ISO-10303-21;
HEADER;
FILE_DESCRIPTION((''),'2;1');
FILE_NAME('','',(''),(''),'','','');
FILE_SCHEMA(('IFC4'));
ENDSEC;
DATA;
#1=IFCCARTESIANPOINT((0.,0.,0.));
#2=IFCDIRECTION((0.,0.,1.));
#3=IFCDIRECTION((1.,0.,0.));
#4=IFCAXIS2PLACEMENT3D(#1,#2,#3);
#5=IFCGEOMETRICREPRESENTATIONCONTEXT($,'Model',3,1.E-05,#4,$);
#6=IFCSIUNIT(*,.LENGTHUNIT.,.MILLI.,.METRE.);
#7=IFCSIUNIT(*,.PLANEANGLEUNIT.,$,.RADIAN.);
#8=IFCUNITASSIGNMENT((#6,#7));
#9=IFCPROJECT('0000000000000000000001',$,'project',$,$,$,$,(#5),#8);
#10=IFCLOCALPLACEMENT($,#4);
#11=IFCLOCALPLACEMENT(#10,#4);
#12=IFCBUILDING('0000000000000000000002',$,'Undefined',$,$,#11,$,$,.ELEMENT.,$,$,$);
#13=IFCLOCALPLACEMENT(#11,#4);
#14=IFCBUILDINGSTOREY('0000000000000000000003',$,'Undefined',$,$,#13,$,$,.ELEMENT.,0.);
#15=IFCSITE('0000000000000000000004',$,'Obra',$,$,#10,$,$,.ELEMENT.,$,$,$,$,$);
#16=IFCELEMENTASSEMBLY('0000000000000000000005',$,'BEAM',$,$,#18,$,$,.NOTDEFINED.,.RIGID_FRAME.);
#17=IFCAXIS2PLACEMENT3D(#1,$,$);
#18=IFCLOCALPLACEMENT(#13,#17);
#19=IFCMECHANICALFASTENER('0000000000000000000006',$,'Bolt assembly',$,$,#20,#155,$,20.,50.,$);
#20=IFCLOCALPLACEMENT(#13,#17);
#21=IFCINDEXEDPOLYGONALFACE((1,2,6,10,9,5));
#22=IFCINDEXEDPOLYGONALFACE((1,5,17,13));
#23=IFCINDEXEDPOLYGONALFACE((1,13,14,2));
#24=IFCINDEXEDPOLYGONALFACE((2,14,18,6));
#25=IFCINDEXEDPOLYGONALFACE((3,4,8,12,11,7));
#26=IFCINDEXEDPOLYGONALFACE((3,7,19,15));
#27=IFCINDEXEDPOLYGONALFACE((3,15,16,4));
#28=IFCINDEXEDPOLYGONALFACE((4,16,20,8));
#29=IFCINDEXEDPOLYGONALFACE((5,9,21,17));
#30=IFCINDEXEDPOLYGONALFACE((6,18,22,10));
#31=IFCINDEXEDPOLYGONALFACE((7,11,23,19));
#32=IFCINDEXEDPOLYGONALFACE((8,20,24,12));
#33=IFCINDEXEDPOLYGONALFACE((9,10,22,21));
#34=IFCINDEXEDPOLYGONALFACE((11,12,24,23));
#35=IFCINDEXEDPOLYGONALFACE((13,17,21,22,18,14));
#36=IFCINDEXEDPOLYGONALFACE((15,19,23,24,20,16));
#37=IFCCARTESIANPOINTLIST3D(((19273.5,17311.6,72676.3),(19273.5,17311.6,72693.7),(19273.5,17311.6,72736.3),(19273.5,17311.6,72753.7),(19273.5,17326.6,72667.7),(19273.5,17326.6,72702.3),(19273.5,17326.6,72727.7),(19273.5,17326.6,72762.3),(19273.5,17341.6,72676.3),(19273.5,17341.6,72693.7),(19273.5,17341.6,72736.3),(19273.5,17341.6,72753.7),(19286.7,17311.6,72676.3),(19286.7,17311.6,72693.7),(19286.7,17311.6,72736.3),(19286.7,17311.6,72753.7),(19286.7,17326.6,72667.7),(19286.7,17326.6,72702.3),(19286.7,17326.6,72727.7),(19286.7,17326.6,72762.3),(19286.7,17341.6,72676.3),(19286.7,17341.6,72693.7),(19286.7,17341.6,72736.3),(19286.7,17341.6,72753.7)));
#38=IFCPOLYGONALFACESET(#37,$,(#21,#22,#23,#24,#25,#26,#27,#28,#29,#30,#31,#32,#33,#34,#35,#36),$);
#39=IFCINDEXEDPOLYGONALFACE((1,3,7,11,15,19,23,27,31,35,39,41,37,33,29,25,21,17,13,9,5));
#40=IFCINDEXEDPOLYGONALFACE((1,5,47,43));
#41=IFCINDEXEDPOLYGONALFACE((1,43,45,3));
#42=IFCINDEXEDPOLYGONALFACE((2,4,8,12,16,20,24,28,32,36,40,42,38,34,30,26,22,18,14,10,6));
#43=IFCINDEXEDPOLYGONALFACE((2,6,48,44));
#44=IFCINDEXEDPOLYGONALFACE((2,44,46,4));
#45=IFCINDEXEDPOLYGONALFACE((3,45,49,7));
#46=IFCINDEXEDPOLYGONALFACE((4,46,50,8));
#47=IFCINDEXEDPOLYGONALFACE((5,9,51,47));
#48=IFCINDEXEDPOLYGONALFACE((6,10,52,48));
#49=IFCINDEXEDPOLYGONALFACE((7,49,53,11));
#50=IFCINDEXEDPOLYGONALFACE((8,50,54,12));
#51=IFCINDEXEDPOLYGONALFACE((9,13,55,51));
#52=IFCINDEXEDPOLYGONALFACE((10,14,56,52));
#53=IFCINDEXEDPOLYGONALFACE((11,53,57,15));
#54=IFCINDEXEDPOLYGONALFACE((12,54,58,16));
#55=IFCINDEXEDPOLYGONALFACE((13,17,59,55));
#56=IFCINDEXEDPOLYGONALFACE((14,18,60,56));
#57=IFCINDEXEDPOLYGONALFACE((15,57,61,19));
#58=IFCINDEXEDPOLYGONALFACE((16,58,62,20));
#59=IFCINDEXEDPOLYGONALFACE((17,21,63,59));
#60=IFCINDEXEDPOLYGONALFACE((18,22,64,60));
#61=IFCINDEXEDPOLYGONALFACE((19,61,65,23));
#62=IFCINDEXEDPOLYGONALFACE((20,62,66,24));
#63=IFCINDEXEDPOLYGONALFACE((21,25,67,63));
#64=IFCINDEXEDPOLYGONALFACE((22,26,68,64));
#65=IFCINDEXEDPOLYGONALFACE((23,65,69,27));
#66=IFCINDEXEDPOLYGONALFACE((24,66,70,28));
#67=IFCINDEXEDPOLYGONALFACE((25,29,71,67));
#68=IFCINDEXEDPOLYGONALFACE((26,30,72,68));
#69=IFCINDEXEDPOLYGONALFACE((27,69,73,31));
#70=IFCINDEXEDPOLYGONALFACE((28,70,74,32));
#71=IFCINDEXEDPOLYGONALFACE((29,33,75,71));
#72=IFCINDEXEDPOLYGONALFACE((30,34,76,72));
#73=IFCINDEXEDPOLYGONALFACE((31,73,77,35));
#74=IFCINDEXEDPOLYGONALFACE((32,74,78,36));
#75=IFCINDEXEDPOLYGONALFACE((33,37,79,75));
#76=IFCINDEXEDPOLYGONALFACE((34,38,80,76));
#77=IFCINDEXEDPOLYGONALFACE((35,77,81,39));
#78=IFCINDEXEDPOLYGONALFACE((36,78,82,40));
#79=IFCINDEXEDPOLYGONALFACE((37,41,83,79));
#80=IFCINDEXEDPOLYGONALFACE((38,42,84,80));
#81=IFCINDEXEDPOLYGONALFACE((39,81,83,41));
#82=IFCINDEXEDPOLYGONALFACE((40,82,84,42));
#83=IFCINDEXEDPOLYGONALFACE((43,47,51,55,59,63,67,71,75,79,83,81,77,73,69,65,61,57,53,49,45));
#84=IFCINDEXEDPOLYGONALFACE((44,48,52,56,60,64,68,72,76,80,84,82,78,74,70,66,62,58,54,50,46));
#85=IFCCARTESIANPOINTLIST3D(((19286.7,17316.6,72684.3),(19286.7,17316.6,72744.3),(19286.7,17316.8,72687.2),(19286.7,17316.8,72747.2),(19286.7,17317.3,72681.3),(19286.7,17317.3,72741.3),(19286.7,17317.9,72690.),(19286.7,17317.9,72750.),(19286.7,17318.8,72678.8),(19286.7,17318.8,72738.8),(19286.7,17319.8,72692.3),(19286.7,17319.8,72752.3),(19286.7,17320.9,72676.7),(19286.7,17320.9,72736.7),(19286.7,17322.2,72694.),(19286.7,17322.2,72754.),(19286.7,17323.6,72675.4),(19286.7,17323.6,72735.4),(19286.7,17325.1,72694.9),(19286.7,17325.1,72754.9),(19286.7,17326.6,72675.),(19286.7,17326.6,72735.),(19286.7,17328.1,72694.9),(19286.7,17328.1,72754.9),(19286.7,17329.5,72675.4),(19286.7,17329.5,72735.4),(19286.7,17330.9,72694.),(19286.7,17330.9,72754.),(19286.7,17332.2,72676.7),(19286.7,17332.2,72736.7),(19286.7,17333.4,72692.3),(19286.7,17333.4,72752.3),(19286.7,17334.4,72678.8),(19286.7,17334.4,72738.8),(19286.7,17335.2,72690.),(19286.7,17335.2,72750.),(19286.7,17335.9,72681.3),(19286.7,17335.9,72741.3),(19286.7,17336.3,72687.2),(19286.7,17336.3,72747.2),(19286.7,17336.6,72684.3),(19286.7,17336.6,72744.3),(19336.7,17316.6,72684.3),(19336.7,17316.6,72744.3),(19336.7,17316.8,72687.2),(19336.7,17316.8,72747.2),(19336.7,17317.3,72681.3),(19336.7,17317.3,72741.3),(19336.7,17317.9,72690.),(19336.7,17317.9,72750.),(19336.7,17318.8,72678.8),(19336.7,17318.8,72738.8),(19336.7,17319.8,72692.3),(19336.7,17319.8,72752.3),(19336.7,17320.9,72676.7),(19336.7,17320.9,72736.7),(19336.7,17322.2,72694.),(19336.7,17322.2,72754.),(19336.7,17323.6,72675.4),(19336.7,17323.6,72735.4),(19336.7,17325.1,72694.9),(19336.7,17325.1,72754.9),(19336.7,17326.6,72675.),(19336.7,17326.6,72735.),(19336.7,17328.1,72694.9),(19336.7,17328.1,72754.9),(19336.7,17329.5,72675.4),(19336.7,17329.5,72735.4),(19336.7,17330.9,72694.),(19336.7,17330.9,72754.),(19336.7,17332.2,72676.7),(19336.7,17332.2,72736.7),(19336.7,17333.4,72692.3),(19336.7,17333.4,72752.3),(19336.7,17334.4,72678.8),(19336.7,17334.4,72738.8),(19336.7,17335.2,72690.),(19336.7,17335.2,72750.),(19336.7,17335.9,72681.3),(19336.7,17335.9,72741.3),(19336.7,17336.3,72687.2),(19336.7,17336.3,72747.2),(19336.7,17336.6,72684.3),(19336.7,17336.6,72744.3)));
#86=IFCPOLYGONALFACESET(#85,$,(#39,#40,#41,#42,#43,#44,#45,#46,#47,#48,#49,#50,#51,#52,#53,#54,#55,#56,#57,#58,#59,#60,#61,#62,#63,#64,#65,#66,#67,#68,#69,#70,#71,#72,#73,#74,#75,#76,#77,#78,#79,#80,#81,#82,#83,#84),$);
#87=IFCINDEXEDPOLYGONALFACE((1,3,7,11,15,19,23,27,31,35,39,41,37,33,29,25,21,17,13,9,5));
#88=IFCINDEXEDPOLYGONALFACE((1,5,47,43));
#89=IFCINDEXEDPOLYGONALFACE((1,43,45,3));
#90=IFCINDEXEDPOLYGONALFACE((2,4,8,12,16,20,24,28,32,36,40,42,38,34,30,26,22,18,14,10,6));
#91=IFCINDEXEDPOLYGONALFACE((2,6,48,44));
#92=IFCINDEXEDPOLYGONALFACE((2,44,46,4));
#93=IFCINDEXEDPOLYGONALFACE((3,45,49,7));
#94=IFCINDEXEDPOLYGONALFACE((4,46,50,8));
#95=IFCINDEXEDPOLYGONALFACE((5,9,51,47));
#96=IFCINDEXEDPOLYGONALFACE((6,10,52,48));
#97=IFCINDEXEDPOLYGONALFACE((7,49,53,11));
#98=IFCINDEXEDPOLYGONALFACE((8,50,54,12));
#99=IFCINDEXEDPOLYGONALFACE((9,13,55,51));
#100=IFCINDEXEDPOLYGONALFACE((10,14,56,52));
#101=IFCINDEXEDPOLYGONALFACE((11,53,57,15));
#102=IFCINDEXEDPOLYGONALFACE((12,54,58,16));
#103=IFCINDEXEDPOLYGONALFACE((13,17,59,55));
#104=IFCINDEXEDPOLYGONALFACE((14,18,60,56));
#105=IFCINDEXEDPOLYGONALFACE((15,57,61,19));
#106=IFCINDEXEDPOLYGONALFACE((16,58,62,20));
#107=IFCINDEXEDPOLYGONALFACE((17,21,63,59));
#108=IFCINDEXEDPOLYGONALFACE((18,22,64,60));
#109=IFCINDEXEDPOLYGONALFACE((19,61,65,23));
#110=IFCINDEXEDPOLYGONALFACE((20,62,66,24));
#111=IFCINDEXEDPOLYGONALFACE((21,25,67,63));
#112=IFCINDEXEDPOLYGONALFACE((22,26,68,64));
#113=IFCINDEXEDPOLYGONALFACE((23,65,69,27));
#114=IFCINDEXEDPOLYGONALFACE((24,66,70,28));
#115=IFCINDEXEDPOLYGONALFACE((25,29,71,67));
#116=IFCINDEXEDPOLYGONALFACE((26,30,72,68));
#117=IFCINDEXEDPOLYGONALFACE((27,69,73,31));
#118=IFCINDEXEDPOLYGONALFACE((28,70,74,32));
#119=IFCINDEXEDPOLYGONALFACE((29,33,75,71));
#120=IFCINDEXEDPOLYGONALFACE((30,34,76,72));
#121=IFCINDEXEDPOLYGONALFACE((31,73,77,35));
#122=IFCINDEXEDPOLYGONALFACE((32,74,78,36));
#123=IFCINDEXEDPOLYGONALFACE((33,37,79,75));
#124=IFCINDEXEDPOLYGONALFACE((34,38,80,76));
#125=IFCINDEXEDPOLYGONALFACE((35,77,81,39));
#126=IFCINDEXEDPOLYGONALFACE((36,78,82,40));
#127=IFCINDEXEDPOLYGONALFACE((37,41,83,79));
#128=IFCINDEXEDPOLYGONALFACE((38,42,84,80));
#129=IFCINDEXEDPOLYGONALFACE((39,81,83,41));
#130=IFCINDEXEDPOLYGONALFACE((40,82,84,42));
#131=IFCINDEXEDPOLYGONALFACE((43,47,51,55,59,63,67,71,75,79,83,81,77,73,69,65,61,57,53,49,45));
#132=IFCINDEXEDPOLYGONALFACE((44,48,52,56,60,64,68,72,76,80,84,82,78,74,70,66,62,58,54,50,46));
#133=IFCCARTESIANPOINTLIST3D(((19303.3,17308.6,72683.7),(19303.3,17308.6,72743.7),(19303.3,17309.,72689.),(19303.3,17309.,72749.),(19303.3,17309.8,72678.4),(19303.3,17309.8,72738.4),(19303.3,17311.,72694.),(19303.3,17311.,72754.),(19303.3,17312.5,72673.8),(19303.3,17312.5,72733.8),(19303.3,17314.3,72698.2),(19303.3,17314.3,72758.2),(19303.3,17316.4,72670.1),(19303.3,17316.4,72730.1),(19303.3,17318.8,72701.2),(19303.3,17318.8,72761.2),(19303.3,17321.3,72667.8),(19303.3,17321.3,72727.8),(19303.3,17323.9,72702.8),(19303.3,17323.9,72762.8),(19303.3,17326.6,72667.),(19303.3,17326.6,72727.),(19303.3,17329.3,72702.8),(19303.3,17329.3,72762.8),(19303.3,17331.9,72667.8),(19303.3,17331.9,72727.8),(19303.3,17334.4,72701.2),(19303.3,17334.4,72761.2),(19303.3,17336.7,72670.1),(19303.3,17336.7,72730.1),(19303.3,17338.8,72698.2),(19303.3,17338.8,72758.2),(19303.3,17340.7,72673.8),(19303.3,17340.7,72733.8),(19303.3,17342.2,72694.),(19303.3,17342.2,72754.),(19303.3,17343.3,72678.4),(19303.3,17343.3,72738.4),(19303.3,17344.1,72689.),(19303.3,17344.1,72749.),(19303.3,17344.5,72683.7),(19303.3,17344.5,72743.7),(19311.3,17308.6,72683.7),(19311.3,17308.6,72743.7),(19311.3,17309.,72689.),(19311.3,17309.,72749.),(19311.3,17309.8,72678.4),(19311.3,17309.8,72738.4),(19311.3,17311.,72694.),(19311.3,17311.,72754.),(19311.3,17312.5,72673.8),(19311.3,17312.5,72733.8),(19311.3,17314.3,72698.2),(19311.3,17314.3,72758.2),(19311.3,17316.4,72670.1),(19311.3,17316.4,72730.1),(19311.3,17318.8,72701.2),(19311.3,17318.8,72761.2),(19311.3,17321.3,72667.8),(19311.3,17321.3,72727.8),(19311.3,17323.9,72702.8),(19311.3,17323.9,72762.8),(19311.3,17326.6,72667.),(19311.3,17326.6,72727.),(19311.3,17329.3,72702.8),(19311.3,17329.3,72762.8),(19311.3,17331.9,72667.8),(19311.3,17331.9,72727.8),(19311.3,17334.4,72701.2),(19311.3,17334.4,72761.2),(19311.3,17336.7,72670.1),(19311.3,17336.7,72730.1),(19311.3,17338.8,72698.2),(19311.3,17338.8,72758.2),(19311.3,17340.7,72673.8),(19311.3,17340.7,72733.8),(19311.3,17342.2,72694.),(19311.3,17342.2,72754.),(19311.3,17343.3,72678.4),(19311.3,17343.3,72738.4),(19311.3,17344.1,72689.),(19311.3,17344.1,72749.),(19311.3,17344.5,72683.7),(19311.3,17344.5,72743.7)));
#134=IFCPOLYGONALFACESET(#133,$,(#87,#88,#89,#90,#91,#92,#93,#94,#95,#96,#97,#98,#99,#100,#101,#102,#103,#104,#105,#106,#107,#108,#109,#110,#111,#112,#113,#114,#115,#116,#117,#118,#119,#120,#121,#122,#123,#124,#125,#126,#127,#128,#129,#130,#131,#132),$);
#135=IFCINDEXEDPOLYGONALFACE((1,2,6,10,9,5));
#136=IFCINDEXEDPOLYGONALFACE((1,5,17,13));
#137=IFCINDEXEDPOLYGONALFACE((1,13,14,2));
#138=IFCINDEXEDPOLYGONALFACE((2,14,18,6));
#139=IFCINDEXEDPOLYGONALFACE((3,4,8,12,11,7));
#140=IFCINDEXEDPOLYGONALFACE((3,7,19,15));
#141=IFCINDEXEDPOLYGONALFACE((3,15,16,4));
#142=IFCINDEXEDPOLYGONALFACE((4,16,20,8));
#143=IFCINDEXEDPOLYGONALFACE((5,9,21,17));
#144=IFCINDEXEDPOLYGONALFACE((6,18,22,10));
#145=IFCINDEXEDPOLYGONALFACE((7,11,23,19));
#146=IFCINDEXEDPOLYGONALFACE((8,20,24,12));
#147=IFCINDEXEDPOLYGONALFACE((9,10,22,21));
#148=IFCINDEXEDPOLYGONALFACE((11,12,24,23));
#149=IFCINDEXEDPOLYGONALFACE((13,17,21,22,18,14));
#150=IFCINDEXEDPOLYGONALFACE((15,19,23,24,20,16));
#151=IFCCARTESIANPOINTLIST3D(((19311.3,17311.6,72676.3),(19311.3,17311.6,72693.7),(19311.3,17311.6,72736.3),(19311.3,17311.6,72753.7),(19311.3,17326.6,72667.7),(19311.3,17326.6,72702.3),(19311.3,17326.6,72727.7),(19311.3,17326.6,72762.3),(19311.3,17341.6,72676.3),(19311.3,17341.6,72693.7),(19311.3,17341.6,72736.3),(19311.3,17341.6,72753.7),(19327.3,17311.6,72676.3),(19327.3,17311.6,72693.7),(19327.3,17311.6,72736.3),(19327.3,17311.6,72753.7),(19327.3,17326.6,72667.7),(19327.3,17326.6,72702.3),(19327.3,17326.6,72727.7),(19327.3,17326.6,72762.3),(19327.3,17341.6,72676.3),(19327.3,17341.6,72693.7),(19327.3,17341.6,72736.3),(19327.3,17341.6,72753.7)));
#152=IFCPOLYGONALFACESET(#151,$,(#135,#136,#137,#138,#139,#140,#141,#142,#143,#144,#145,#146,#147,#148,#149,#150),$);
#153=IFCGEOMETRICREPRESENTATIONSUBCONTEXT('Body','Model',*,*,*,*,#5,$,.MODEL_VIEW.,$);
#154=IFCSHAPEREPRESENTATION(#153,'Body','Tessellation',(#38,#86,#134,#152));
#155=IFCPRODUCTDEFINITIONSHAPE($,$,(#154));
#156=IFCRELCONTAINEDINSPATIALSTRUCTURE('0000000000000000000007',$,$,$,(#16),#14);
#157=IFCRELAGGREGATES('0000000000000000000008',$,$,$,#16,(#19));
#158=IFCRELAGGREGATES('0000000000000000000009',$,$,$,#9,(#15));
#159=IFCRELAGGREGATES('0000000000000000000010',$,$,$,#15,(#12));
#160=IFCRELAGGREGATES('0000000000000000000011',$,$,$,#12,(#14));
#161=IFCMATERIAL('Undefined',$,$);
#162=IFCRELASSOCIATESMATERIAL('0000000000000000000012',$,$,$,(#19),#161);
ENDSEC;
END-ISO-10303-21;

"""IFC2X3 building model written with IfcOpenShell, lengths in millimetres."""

from ifc_helpers import new_model, si_unit, frame, origin_with_axes, origin_2d_with_axis, place, context, subcontext, project, spatial, polyline, circle, outline, extrude, source, transform, mapped, material, element, aggregate, save


model = new_model("IFC2X3")

# Units and contexts
model_context = context("Model", 3, precision=1e-05, world=origin_with_axes())
body_context = subcontext(model_context, "Body", "Model", "MODEL_VIEW")
ifc_project = project(units=[si_unit("LENGTHUNIT", "METRE", prefix="MILLI"), si_unit("PLANEANGLEUNIT", "RADIAN")], contexts=[model_context])

# Site, building, storey
site_placement = place(None, origin_with_axes())
site = spatial("IfcSite", under=ifc_project, at=site_placement, Name="Obra", CompositionType="ELEMENT")
building_placement = place(site_placement, origin_with_axes())
building = spatial("IfcBuilding", under=site, at=building_placement, Name="Undefined", CompositionType="ELEMENT")
storey_placement = place(building_placement, origin_with_axes())
storey = spatial("IfcBuildingStorey", under=building, at=storey_placement, Name="Undefined", CompositionType="ELEMENT", Elevation=0.0)

# Shared definitions
ifc_material = material(Name="Undefined")

# Shared definitions
shared_shape_1 = source(origin_with_axes(), body_context, "Body", "SweptSolid", [
    extrude(outline(polyline([(17.3, 0.0), (8.7, 15.0), (-8.7, 15.0), (-17.3, 0.0), (-8.7, -15.0), (8.7, -15.0), (17.3, 0.0)])), frame((0.0, -26.5, 0.0), z_axis=(0.0, 1.0, 0.0), x_axis=(1.0, 0.0, 0.0)), (0.0, 0.0, 1.0), 13.2),
    extrude(circle(Radius=10.0, at=origin_2d_with_axis()), frame((0.0, -13.3, 0.0), z_axis=(0.0, 1.0, 0.0), x_axis=(1.0, 0.0, 0.0)), (0.0, 0.0, 1.0), 50.0),
    extrude(circle(Radius=18.0, at=origin_2d_with_axis()), frame((0.0, 3.3, 0.0), z_axis=(0.0, 1.0, 0.0), x_axis=(1.0, 0.0, 0.0)), (0.0, 0.0, 1.0), 8.0),
    extrude(outline(polyline([(17.3, 0.0), (8.7, 15.0), (-8.7, 15.0), (-17.3, 0.0), (-8.7, -15.0), (8.7, -15.0), (17.3, 0.0)])), frame((0.0, 11.3, 0.0), z_axis=(0.0, 1.0, 0.0), x_axis=(1.0, 0.0, 0.0)), (0.0, 0.0, 1.0), 16.0),
])

# Element assembly, mechanical fastener
assembly_1_placement = place(storey_placement, origin_with_axes())
assembly_1 = element("IfcElementAssembly", 1, at=assembly_1_placement, inside=storey, Name="BEAM", AssemblyPlace="NOTDEFINED", PredefinedType="RIGID_FRAME")
mechanical_fastener_1_placement = place(assembly_1_placement, frame((19300.0, 17366.6, 72850.0), z_axis=(0.0, -1.0, 0.0), x_axis=(0.0, 0.0, -1.0)))
mechanical_fastener_1 = element("IfcMechanicalFastener", 2, at=mechanical_fastener_1_placement, material=ifc_material, Name="Bolt assembly", NominalDiameter=20.0, NominalLength=50.0, context=body_context, shape_type="MappedRepresentation", body=[
    mapped(shared_shape_1, transform((105.0, 0.0, 40.0))),
    mapped(shared_shape_1, transform((165.0, 0.0, 40.0))),
])
aggregate(assembly_1, [mechanical_fastener_1])

save(model, "model.ifc")
